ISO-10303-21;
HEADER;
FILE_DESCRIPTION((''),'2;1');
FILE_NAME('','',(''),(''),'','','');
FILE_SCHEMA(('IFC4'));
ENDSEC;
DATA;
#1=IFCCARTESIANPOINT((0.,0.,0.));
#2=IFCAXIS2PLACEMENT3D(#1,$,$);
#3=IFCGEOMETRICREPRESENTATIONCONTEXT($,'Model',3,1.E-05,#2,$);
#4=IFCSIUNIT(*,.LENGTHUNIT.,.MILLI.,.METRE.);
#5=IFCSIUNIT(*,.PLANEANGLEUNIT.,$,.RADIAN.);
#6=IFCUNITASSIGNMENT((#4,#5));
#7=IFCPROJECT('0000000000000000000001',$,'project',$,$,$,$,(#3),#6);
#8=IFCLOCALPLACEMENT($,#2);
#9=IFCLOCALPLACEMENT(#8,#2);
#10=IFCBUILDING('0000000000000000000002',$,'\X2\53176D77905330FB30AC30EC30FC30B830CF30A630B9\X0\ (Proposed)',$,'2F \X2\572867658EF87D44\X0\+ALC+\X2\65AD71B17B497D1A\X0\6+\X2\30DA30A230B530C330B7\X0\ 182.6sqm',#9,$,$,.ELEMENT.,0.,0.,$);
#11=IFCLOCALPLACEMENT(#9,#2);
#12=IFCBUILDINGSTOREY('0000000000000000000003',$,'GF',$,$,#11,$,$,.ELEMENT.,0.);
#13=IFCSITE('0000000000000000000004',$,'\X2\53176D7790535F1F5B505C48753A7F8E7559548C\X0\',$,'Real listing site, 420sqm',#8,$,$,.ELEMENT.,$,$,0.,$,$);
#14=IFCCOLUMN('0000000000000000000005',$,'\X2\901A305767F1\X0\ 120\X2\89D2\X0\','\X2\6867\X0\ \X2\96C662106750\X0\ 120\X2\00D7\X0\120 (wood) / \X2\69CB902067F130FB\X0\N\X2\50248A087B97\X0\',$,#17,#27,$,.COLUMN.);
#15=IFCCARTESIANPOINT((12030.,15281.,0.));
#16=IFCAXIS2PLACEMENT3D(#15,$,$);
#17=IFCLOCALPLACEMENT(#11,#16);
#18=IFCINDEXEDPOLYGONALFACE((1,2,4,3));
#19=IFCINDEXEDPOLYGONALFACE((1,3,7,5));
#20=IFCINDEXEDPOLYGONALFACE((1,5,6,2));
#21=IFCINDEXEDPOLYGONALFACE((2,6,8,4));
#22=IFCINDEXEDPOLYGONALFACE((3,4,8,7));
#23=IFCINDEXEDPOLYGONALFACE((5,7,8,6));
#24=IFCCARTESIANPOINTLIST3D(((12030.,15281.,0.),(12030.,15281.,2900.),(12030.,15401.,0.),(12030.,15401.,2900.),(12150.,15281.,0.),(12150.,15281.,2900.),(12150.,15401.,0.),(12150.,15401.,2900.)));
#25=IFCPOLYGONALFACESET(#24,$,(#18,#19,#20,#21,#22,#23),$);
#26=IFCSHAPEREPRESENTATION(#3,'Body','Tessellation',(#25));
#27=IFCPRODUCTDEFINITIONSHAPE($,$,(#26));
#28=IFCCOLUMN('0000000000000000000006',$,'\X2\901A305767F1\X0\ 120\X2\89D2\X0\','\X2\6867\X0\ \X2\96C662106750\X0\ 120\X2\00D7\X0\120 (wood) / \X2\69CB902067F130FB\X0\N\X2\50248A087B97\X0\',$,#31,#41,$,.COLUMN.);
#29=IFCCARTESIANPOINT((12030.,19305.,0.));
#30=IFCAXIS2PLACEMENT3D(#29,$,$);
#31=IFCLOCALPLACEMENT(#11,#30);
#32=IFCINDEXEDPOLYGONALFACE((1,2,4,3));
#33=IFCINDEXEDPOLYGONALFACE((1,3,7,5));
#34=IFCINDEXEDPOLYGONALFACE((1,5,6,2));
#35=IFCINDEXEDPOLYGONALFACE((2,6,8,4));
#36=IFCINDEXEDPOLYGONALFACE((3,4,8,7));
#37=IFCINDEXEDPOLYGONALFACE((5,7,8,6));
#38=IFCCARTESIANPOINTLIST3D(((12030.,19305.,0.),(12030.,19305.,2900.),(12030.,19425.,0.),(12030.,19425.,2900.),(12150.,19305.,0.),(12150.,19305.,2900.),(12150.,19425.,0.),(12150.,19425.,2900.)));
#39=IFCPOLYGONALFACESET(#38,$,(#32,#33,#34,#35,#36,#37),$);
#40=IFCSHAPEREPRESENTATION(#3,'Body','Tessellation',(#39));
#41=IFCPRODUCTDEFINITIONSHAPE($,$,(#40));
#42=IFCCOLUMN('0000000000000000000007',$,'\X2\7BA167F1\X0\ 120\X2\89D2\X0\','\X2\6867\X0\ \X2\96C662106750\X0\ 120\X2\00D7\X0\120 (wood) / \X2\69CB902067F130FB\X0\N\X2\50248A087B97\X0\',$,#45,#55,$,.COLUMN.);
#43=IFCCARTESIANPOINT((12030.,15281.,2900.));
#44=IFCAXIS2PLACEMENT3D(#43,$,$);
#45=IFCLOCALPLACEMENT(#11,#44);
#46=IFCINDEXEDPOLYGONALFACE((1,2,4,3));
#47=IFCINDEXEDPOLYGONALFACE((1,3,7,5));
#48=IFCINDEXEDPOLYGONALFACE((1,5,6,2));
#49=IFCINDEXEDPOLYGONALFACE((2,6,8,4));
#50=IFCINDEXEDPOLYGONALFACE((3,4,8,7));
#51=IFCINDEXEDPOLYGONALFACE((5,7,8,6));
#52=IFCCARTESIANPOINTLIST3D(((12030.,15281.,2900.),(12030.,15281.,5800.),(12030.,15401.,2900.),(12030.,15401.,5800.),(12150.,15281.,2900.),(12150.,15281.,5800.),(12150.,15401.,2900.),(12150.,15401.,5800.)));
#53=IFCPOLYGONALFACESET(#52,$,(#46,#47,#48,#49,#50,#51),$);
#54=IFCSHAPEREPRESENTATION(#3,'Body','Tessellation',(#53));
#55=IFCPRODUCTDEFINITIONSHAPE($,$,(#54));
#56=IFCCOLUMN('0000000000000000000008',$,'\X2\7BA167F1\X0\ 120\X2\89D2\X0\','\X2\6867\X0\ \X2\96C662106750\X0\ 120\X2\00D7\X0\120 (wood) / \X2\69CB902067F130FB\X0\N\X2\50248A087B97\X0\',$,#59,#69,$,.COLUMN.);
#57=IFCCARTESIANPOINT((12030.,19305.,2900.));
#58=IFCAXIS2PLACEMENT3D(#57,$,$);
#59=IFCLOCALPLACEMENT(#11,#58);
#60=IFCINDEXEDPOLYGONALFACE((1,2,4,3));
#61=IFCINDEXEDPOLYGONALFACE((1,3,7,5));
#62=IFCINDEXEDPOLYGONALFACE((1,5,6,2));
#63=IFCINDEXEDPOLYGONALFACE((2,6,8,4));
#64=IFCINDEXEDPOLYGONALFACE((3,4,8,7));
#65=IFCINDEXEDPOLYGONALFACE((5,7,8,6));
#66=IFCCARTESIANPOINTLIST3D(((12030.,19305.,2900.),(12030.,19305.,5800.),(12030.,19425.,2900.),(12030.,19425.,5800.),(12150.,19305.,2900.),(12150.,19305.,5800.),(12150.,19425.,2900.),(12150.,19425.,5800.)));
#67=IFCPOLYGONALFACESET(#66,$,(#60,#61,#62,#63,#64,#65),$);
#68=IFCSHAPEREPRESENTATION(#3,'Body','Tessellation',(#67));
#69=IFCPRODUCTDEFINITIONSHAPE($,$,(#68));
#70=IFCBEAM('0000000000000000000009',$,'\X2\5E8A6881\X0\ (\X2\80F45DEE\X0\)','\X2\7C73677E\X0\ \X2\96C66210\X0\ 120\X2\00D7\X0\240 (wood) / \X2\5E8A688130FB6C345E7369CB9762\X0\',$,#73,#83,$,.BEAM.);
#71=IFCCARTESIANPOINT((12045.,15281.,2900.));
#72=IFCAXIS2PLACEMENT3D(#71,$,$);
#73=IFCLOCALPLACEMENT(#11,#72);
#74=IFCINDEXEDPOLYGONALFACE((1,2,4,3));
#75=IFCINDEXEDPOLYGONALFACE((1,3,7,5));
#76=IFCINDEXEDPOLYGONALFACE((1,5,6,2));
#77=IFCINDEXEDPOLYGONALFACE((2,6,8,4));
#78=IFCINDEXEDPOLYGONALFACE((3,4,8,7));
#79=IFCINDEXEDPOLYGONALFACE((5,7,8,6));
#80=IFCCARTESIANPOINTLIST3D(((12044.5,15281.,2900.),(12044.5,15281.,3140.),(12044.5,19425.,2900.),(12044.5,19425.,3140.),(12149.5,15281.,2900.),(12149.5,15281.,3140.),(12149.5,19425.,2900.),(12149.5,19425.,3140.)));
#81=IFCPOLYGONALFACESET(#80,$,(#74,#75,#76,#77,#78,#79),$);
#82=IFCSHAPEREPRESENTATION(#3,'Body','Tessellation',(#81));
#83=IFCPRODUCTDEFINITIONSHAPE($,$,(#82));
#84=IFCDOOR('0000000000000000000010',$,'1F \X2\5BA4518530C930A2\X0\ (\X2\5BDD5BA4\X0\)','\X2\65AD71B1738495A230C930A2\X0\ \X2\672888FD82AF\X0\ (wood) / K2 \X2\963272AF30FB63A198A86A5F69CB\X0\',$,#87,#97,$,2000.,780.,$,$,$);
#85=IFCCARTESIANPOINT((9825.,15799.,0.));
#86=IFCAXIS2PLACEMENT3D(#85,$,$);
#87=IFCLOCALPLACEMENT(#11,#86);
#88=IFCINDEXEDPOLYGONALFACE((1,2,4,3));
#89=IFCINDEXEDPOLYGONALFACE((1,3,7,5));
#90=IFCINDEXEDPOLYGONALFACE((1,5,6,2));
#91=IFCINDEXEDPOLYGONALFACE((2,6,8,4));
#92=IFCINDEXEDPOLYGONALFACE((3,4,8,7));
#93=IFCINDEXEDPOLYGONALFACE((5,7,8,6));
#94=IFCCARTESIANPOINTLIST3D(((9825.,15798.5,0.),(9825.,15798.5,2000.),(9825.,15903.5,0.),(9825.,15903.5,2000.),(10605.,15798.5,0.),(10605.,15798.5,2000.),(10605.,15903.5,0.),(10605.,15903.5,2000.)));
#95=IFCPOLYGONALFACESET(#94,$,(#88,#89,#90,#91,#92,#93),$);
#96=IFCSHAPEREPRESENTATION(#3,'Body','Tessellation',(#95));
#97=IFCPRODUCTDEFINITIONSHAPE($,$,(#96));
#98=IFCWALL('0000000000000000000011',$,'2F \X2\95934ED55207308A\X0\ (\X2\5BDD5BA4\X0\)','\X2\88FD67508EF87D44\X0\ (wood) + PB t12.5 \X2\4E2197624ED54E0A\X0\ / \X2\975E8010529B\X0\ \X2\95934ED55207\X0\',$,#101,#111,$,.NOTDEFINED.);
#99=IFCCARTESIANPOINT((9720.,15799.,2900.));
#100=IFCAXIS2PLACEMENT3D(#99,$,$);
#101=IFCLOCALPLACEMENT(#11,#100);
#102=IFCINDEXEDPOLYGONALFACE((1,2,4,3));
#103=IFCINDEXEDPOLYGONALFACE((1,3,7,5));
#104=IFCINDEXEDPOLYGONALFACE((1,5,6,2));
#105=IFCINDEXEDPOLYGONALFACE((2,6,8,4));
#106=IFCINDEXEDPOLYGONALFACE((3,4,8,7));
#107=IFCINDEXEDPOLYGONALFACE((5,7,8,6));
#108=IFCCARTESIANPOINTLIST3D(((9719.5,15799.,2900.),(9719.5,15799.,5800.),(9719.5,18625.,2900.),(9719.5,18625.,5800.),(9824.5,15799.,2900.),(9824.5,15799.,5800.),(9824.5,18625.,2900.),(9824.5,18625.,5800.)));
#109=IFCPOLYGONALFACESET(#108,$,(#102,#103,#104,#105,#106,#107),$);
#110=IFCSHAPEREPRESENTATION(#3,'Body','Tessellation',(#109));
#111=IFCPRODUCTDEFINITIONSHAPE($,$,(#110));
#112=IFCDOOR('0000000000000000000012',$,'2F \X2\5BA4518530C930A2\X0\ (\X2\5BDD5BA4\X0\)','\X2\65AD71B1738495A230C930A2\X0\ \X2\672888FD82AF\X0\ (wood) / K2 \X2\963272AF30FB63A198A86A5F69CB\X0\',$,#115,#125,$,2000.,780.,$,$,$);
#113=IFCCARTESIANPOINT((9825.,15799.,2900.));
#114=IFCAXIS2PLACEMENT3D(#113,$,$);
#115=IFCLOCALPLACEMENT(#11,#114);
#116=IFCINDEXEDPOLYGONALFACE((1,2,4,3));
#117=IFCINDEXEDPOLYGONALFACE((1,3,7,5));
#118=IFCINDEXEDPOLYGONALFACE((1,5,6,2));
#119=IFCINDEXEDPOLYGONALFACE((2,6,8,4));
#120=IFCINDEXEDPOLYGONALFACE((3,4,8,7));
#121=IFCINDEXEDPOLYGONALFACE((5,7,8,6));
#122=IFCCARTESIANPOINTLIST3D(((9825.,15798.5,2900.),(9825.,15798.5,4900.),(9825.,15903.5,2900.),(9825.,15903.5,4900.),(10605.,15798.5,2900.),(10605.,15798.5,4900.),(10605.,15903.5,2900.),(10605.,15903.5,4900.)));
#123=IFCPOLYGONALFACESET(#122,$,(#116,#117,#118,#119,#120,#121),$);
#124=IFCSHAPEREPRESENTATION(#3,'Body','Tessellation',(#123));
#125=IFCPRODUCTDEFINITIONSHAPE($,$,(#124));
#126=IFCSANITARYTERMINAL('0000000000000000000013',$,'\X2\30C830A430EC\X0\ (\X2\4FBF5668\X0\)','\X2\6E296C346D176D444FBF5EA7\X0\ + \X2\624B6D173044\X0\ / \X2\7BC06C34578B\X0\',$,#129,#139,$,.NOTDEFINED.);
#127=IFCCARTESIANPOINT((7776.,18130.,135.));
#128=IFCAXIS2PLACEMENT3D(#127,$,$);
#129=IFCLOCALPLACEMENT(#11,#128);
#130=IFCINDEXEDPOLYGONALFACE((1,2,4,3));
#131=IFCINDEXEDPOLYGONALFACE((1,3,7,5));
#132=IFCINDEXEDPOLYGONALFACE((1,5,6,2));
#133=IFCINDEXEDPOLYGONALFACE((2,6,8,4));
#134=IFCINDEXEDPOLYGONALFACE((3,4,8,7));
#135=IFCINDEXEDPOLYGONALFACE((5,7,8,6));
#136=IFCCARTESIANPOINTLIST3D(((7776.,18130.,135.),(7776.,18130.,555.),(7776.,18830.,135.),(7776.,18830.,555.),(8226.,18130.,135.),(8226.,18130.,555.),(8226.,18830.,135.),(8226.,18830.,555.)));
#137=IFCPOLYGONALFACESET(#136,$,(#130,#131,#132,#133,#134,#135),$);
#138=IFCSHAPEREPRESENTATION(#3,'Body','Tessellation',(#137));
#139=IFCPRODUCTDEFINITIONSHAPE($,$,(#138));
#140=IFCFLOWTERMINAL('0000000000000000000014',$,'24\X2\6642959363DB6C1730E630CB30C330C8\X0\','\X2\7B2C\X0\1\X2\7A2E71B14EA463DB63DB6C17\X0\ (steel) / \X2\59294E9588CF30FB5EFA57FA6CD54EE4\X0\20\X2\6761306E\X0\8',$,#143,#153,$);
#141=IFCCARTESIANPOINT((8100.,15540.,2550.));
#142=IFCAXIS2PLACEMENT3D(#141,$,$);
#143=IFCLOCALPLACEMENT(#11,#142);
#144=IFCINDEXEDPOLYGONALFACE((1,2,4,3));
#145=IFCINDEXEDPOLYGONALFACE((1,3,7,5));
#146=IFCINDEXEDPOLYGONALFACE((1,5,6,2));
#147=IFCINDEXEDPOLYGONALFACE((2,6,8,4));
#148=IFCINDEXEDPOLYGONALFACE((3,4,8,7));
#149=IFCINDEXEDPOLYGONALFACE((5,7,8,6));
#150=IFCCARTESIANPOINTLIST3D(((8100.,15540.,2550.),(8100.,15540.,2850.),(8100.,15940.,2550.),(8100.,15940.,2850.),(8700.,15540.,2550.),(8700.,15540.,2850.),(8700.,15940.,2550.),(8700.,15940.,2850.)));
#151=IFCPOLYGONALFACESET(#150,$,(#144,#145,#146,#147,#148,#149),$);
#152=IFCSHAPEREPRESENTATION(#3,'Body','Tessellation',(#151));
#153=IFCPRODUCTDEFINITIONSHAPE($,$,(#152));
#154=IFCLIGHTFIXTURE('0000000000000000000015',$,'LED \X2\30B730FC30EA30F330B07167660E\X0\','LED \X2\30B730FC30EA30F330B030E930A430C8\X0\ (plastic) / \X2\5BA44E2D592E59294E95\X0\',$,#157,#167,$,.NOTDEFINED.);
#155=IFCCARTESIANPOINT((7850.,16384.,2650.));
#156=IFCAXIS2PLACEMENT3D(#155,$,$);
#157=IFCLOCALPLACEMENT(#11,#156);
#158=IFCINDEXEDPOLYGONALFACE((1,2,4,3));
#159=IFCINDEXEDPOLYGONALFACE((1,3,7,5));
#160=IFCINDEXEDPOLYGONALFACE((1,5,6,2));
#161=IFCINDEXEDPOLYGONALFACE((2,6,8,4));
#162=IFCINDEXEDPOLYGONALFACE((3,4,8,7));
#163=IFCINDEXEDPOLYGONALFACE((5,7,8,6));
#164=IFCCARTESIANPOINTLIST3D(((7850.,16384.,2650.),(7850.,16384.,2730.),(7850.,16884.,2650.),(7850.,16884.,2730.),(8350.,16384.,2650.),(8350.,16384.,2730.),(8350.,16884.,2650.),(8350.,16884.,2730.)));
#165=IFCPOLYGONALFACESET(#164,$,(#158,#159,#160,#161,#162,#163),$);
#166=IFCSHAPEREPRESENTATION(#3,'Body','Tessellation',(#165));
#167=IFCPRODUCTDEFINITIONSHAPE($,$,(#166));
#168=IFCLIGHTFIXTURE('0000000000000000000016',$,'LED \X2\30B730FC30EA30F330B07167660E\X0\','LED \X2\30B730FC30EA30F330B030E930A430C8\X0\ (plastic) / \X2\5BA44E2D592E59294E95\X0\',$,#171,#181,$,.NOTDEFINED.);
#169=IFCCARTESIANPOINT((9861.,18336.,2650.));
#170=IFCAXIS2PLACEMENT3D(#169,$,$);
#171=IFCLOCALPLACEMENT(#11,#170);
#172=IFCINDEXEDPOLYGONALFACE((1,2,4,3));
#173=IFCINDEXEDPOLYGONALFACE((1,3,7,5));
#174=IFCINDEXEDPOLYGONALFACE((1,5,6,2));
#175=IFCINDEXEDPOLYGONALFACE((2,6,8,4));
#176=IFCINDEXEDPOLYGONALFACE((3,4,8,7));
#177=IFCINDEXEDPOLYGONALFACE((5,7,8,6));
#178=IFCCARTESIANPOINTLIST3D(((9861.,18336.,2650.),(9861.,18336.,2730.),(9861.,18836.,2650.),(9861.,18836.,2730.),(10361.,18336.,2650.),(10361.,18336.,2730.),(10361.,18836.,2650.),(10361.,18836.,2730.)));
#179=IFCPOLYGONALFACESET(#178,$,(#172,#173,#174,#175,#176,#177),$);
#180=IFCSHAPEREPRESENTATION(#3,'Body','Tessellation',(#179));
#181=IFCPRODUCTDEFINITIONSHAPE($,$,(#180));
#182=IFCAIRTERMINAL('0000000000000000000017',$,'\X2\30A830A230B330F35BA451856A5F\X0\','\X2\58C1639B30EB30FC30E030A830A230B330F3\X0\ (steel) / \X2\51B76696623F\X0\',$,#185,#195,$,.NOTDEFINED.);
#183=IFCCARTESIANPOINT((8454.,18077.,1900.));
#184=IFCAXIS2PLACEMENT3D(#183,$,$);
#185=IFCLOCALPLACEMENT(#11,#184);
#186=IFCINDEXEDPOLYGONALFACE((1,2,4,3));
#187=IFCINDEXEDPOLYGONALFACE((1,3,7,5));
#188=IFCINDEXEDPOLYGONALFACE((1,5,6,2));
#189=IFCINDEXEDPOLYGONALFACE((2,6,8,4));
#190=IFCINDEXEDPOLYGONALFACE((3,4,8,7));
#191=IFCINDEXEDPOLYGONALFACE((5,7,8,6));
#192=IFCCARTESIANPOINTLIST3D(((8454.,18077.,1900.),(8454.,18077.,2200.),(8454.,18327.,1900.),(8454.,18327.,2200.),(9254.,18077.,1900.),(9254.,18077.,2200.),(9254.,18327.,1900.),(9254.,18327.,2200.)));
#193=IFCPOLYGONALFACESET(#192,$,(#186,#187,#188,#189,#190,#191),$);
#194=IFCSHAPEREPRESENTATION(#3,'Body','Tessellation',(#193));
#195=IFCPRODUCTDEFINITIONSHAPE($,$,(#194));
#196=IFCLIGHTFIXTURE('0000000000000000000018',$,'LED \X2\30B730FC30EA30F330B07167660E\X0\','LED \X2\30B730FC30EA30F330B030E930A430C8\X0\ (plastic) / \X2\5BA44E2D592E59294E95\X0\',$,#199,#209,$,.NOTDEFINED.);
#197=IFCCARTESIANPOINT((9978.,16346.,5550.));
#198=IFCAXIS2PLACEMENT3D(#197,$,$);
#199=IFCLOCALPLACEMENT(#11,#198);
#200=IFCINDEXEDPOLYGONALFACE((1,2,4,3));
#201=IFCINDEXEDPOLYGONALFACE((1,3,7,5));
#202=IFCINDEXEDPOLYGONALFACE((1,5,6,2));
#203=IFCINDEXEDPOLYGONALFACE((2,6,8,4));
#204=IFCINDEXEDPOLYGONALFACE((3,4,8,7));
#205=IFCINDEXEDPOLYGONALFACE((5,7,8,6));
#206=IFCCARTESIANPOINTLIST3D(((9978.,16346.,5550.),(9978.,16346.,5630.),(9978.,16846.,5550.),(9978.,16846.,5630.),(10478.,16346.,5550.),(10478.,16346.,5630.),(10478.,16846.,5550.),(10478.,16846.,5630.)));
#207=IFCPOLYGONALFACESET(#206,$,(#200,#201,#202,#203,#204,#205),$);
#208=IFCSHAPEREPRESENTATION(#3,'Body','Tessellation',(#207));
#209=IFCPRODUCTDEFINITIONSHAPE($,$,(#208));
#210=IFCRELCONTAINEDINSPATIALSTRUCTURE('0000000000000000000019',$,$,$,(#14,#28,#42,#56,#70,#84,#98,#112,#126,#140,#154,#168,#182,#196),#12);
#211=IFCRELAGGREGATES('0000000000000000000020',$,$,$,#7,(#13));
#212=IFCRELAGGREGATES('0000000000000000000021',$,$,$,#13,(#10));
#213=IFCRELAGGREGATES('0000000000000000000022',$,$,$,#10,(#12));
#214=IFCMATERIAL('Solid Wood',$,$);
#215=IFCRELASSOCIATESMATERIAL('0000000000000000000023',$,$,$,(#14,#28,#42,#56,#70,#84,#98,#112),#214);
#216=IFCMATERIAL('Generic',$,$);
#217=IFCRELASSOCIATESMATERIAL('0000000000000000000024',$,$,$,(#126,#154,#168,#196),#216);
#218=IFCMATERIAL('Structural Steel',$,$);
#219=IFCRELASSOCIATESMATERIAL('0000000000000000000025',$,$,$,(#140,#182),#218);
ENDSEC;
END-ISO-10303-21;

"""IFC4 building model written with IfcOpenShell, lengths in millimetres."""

from ifc_helpers import new_model, si_unit, frame, frame_2d, origin, place, context, project, spatial, rectangle, extrude, material, element, save


model = new_model("IFC4")

# Units and contexts
model_context = context("Model", 3, precision=1e-05, world=origin())
ifc_project = project(units=[si_unit("LENGTHUNIT", "METRE", prefix="MILLI"), si_unit("PLANEANGLEUNIT", "RADIAN")], contexts=[model_context])

# Site, building, storey
site_placement = place(None, origin())
site = spatial("IfcSite", under=ifc_project, at=site_placement, Name="北海道弟子屈町美留和", ObjectType="Real listing site, 420sqm", CompositionType="ELEMENT", RefElevation=0.0)
building_placement = place(site_placement, origin())
building = spatial("IfcBuilding", under=site, at=building_placement, Name="北海道・ガレージハウス (Proposed)", ObjectType="2F 在来軸組+ALC+断熱等級6+ペアサッシ 182.6sqm", CompositionType="ELEMENT", ElevationOfRefHeight=0.0, ElevationOfTerrain=0.0)
storey_placement = place(building_placement, origin())
storey = spatial("IfcBuildingStorey", under=building, at=storey_placement, Name="GF", CompositionType="ELEMENT", Elevation=0.0)

# Columns
ifc_material_1 = material(Name="Solid Wood")
column_1_placement = place(storey_placement, frame((12030.0, 15281.0, 0.0)))
element("IfcColumn", 1, at=column_1_placement, inside=storey, material=ifc_material_1, Name="通し柱 120角", Description="桧 集成材 120×120 (wood) / 構造柱・N値計算", PredefinedType="COLUMN", context=model_context, shape_type="SweptSolid", body=[
    extrude(rectangle(XDim=120.0, YDim=120.0, at=frame_2d((60.0, 60.0))), frame((12030.0, 15281.0, 0.0)), (0.0, 0.0, 1.0), 2900.0),
])
column_2_placement = place(storey_placement, frame((12030.0, 19305.0, 0.0)))
element("IfcColumn", 2, at=column_2_placement, inside=storey, material=ifc_material_1, Name="通し柱 120角", Description="桧 集成材 120×120 (wood) / 構造柱・N値計算", PredefinedType="COLUMN", context=model_context, shape_type="SweptSolid", body=[
    extrude(rectangle(XDim=120.0, YDim=120.0, at=frame_2d((60.0, 60.0))), frame((12030.0, 19305.0, 0.0)), (0.0, 0.0, 1.0), 2900.0),
])
column_3_placement = place(storey_placement, frame((12030.0, 15281.0, 2900.0)))
element("IfcColumn", 3, at=column_3_placement, inside=storey, material=ifc_material_1, Name="管柱 120角", Description="桧 集成材 120×120 (wood) / 構造柱・N値計算", PredefinedType="COLUMN", context=model_context, shape_type="SweptSolid", body=[
    extrude(rectangle(XDim=120.0, YDim=120.0, at=frame_2d((60.0, 60.0))), frame((12030.0, 15281.0, 2900.0)), (0.0, 0.0, 1.0), 2900.0),
])
column_4_placement = place(storey_placement, frame((12030.0, 19305.0, 2900.0)))
element("IfcColumn", 4, at=column_4_placement, inside=storey, material=ifc_material_1, Name="管柱 120角", Description="桧 集成材 120×120 (wood) / 構造柱・N値計算", PredefinedType="COLUMN", context=model_context, shape_type="SweptSolid", body=[
    extrude(rectangle(XDim=120.0, YDim=120.0, at=frame_2d((60.0, 60.0))), frame((12030.0, 19305.0, 2900.0)), (0.0, 0.0, 1.0), 2900.0),
])

# Beam
beam_1_placement = place(storey_placement, frame((12045.0, 15281.0, 2900.0)))
element("IfcBeam", 5, at=beam_1_placement, inside=storey, material=ifc_material_1, Name="床梁 (胴差)", Description="米松 集成 120×240 (wood) / 床梁・水平構面", PredefinedType="BEAM", context=model_context, shape_type="SweptSolid", body=[
    extrude(rectangle(XDim=105.0, YDim=4144.0, at=frame_2d((52.0, 2072.0))), frame((12045.0, 15281.0, 2900.0)), (0.0, 0.0, 1.0), 240.0),
])

# Door
door_1_placement = place(storey_placement, frame((9825.0, 15799.0, 0.0)))
element("IfcDoor", 6, at=door_1_placement, inside=storey, material=ifc_material_1, Name="1F 室内ドア (寝室)", Description="断熱玄関ドア 木製芯 (wood) / K2 防犯・採風機構", OverallHeight=2000.0, OverallWidth=780.0, context=model_context, shape_type="SweptSolid", body=[
    extrude(rectangle(XDim=780.0, YDim=105.0, at=frame_2d((390.0, 52.0))), frame((9825.0, 15799.0, 0.0)), (0.0, 0.0, 1.0), 2000.0),
])

# Wall
wall_1_placement = place(storey_placement, frame((9720.0, 15799.0, 2900.0)))
element("IfcWall", 7, at=wall_1_placement, inside=storey, material=ifc_material_1, Name="2F 間仕切り (寝室)", Description="製材軸組 (wood) + PB t12.5 両面仕上 / 非耐力 間仕切", PredefinedType="NOTDEFINED", context=model_context, shape_type="SweptSolid", body=[
    extrude(rectangle(XDim=105.0, YDim=2826.0, at=frame_2d((52.0, 1413.0))), frame((9720.0, 15799.0, 2900.0)), (0.0, 0.0, 1.0), 2900.0),
])

# Door
door_2_placement = place(storey_placement, frame((9825.0, 15799.0, 2900.0)))
element("IfcDoor", 8, at=door_2_placement, inside=storey, material=ifc_material_1, Name="2F 室内ドア (寝室)", Description="断熱玄関ドア 木製芯 (wood) / K2 防犯・採風機構", OverallHeight=2000.0, OverallWidth=780.0, context=model_context, shape_type="SweptSolid", body=[
    extrude(rectangle(XDim=780.0, YDim=105.0, at=frame_2d((390.0, 52.0))), frame((9825.0, 15799.0, 2900.0)), (0.0, 0.0, 1.0), 2000.0),
])

# Sanitary terminal
ifc_material_2 = material(Name="Generic")
sanitary_terminal_placement = place(storey_placement, frame((7776.0, 18130.0, 135.0)))
element("IfcSanitaryTerminal", 9, at=sanitary_terminal_placement, inside=storey, material=ifc_material_2, Name="トイレ (便器)", Description="温水洗浄便座 + 手洗い / 節水型", PredefinedType="NOTDEFINED", context=model_context, shape_type="SweptSolid", body=[
    extrude(rectangle(XDim=450.0, YDim=700.0, at=frame_2d((225.0, 350.0))), frame((7776.0, 18130.0, 135.0)), (0.0, 0.0, 1.0), 420.0),
])

# Flow terminal
ifc_material_3 = material(Name="Structural Steel")
flow_terminal_placement = place(storey_placement, frame((8100.0, 15540.0, 2550.0)))
element("IfcFlowTerminal", 10, at=flow_terminal_placement, inside=storey, material=ifc_material_3, Name="24時間換気ユニット", Description="第1種熱交換換気 (steel) / 天井裏・建基法令20条の8", context=model_context, shape_type="SweptSolid", body=[
    extrude(rectangle(XDim=600.0, YDim=400.0, at=frame_2d((300.0, 200.0))), frame((8100.0, 15540.0, 2550.0)), (0.0, 0.0, 1.0), 300.0),
])

# Light fixtures
light_fixture_1_placement = place(storey_placement, frame((7850.0, 16384.0, 2650.0)))
element("IfcLightFixture", 11, at=light_fixture_1_placement, inside=storey, material=ifc_material_2, Name="LED シーリング照明", Description="LED シーリングライト (plastic) / 室中央天井", PredefinedType="NOTDEFINED", context=model_context, shape_type="SweptSolid", body=[
    extrude(rectangle(XDim=500.0, YDim=500.0, at=frame_2d((250.0, 250.0))), frame((7850.0, 16384.0, 2650.0)), (0.0, 0.0, 1.0), 80.0),
])
light_fixture_2_placement = place(storey_placement, frame((9861.0, 18336.0, 2650.0)))
element("IfcLightFixture", 12, at=light_fixture_2_placement, inside=storey, material=ifc_material_2, Name="LED シーリング照明", Description="LED シーリングライト (plastic) / 室中央天井", PredefinedType="NOTDEFINED", context=model_context, shape_type="SweptSolid", body=[
    extrude(rectangle(XDim=500.0, YDim=500.0, at=frame_2d((250.0, 250.0))), frame((9861.0, 18336.0, 2650.0)), (0.0, 0.0, 1.0), 80.0),
])

# Air terminal
air_terminal_1_placement = place(storey_placement, frame((8454.0, 18077.0, 1900.0)))
element("IfcAirTerminal", 13, at=air_terminal_1_placement, inside=storey, material=ifc_material_3, Name="エアコン室内機", Description="壁掛ルームエアコン (steel) / 冷暖房", PredefinedType="NOTDEFINED", context=model_context, shape_type="SweptSolid", body=[
    extrude(rectangle(XDim=800.0, YDim=250.0, at=frame_2d((400.0, 125.0))), frame((8454.0, 18077.0, 1900.0)), (0.0, 0.0, 1.0), 300.0),
])

# Light fixture
light_fixture_3_placement = place(storey_placement, frame((9978.0, 16346.0, 5550.0)))
element("IfcLightFixture", 14, at=light_fixture_3_placement, inside=storey, material=ifc_material_2, Name="LED シーリング照明", Description="LED シーリングライト (plastic) / 室中央天井", PredefinedType="NOTDEFINED", context=model_context, shape_type="SweptSolid", body=[
    extrude(rectangle(XDim=500.0, YDim=500.0, at=frame_2d((250.0, 250.0))), frame((9978.0, 16346.0, 5550.0)), (0.0, 0.0, 1.0), 80.0),
])

save(model, "model.ifc")
